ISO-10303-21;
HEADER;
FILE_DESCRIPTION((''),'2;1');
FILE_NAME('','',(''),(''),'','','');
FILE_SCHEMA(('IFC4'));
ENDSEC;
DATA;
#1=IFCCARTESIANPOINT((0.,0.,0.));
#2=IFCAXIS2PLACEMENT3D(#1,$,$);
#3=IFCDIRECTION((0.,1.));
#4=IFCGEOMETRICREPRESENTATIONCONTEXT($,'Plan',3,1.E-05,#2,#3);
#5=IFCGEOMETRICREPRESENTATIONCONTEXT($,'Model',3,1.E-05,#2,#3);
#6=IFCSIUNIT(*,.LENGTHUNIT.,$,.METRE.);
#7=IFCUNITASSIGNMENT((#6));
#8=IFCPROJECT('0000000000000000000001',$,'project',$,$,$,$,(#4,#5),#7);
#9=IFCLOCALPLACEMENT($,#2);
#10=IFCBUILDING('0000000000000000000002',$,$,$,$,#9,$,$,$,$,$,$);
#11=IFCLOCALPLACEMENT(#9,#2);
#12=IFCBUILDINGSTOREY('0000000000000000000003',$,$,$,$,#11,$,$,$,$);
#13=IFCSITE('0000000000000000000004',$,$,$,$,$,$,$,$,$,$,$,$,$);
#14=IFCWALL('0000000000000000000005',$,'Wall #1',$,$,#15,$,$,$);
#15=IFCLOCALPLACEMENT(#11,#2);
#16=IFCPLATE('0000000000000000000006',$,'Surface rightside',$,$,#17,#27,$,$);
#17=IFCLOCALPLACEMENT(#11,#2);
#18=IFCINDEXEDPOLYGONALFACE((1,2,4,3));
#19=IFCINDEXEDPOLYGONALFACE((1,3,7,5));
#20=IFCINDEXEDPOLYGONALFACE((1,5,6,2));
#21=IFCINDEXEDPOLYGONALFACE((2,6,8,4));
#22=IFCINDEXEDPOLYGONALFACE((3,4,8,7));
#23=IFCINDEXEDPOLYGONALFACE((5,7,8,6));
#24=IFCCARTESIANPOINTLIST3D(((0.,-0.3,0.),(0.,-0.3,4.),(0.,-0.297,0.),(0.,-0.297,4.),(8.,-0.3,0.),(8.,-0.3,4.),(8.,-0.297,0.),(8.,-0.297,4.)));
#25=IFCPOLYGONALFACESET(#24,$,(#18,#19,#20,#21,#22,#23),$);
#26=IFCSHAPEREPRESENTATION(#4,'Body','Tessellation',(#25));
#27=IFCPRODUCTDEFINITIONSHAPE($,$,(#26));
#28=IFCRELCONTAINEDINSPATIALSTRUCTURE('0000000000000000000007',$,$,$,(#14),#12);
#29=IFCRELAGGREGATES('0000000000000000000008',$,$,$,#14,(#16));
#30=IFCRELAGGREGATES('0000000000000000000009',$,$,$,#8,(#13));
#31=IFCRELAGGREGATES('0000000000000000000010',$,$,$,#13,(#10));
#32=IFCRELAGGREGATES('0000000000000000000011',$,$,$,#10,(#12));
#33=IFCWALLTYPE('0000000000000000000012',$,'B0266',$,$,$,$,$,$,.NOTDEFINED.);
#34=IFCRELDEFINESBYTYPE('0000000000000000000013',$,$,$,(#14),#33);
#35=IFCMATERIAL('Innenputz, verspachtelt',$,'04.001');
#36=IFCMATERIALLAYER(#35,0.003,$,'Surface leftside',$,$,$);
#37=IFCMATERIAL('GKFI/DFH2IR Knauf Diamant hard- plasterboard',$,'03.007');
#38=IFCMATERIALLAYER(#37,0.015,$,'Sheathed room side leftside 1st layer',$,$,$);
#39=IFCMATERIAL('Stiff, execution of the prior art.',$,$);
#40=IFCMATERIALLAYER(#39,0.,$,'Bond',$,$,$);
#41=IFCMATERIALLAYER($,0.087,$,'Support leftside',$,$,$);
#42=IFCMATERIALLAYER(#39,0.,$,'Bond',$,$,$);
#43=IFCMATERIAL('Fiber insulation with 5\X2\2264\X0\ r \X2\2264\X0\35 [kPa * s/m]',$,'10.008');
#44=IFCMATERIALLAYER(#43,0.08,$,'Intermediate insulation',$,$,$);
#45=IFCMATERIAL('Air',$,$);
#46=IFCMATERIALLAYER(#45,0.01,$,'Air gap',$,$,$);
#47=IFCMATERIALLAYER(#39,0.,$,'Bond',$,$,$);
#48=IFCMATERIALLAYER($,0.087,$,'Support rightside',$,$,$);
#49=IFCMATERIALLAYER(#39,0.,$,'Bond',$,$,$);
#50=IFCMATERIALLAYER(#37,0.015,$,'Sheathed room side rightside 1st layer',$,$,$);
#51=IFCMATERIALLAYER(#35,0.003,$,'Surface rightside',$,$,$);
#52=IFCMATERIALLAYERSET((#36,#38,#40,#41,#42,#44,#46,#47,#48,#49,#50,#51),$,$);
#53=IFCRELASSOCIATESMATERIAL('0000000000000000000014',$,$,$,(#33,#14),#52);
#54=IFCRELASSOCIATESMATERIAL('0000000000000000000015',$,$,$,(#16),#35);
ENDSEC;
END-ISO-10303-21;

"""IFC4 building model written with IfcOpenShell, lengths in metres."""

from ifc_helpers import new_model, si_unit, direction, frame, frame_2d, origin, place, context, project, spatial, rectangle, extrude, material, layer, layer_set, type_object, element, aggregate, save


model = new_model("IFC4")

# Units and contexts
plan_context = context("Plan", 3, precision=1e-05, world=origin(), true_north=direction((0.0, 1.0)))
model_context = context("Model", 3, precision=1e-05, world=origin(), true_north=direction((0.0, 1.0)))
ifc_project = project(units=[si_unit("LENGTHUNIT", "METRE")], contexts=[plan_context, model_context])

# Site, building, storey
site = spatial("IfcSite", under=ifc_project)
building_placement = place(None, origin())
building = spatial("IfcBuilding", under=site, at=building_placement)
storey_placement = place(building_placement, origin())
storey = spatial("IfcBuildingStorey", under=building, at=storey_placement)

# Wall, plate
ifc_material_1 = material(Name="Innenputz, verspachtelt", Category="04.001")
ifc_layer_1 = layer(ifc_material_1, 0.003, Name="Surface leftside")
ifc_material_2 = material(Name="GKFI/DFH2IR Knauf Diamant hard- plasterboard", Category="03.007")
ifc_layer_2 = layer(ifc_material_2, 0.015, Name="Sheathed room side leftside 1st layer")
ifc_material_3 = material(Name="Stiff, execution of the prior art.")
ifc_layer_3 = layer(ifc_material_3, 0.0, Name="Bond")
ifc_layer_4 = layer(None, 0.087, Name="Support leftside")
ifc_layer_5 = layer(ifc_material_3, 0.0, Name="Bond")
ifc_material_4 = material(Name="Fiber insulation with 5≤ r ≤35 [kPa * s/m]", Category="10.008")
ifc_layer_6 = layer(ifc_material_4, 0.08, Name="Intermediate insulation")
ifc_material_5 = material(Name="Air")
ifc_layer_7 = layer(ifc_material_5, 0.01, Name="Air gap")
ifc_layer_8 = layer(ifc_material_3, 0.0, Name="Bond")
ifc_layer_9 = layer(None, 0.087, Name="Support rightside")
ifc_layer_10 = layer(ifc_material_3, 0.0, Name="Bond")
ifc_layer_11 = layer(ifc_material_2, 0.015, Name="Sheathed room side rightside 1st layer")
ifc_layer_12 = layer(ifc_material_1, 0.003, Name="Surface rightside")
ifc_layer_set = layer_set([ifc_layer_1, ifc_layer_2, ifc_layer_3, ifc_layer_4, ifc_layer_5, ifc_layer_6, ifc_layer_7, ifc_layer_8, ifc_layer_9, ifc_layer_10, ifc_layer_11, ifc_layer_12])
wall_type = type_object("IfcWallType", Name="B0266", PredefinedType="NOTDEFINED", material=ifc_layer_set)
wall_placement = place(None, frame((0.0, 0.0, 0.0), z_axis=(0.0, -1.0, 0.0), x_axis=(1.0, 0.0, 0.0)))
wall = element("IfcWall", 1, at=wall_placement, inside=storey, type_object=wall_type, material=ifc_layer_set, Name="Wall #1")
plate_1_placement = place(wall_placement, origin())
plate_1 = element("IfcPlate", 2, at=plate_1_placement, material=ifc_material_1, Name="Surface rightside", context=plan_context, shape_type="SweptSolid", body=[
    extrude(rectangle(XDim=8.0, YDim=4.0, at=frame_2d((4.0, 2.0), x_axis=(1.0, 0.0))), frame((0.0, 0.0, 0.297), z_axis=(0.0, 0.0, 1.0), x_axis=(1.0, 0.0, 0.0)), (0.0, 0.0, 1.0), 0.003),
])
aggregate(wall, [plate_1])

save(model, "model.ifc")
